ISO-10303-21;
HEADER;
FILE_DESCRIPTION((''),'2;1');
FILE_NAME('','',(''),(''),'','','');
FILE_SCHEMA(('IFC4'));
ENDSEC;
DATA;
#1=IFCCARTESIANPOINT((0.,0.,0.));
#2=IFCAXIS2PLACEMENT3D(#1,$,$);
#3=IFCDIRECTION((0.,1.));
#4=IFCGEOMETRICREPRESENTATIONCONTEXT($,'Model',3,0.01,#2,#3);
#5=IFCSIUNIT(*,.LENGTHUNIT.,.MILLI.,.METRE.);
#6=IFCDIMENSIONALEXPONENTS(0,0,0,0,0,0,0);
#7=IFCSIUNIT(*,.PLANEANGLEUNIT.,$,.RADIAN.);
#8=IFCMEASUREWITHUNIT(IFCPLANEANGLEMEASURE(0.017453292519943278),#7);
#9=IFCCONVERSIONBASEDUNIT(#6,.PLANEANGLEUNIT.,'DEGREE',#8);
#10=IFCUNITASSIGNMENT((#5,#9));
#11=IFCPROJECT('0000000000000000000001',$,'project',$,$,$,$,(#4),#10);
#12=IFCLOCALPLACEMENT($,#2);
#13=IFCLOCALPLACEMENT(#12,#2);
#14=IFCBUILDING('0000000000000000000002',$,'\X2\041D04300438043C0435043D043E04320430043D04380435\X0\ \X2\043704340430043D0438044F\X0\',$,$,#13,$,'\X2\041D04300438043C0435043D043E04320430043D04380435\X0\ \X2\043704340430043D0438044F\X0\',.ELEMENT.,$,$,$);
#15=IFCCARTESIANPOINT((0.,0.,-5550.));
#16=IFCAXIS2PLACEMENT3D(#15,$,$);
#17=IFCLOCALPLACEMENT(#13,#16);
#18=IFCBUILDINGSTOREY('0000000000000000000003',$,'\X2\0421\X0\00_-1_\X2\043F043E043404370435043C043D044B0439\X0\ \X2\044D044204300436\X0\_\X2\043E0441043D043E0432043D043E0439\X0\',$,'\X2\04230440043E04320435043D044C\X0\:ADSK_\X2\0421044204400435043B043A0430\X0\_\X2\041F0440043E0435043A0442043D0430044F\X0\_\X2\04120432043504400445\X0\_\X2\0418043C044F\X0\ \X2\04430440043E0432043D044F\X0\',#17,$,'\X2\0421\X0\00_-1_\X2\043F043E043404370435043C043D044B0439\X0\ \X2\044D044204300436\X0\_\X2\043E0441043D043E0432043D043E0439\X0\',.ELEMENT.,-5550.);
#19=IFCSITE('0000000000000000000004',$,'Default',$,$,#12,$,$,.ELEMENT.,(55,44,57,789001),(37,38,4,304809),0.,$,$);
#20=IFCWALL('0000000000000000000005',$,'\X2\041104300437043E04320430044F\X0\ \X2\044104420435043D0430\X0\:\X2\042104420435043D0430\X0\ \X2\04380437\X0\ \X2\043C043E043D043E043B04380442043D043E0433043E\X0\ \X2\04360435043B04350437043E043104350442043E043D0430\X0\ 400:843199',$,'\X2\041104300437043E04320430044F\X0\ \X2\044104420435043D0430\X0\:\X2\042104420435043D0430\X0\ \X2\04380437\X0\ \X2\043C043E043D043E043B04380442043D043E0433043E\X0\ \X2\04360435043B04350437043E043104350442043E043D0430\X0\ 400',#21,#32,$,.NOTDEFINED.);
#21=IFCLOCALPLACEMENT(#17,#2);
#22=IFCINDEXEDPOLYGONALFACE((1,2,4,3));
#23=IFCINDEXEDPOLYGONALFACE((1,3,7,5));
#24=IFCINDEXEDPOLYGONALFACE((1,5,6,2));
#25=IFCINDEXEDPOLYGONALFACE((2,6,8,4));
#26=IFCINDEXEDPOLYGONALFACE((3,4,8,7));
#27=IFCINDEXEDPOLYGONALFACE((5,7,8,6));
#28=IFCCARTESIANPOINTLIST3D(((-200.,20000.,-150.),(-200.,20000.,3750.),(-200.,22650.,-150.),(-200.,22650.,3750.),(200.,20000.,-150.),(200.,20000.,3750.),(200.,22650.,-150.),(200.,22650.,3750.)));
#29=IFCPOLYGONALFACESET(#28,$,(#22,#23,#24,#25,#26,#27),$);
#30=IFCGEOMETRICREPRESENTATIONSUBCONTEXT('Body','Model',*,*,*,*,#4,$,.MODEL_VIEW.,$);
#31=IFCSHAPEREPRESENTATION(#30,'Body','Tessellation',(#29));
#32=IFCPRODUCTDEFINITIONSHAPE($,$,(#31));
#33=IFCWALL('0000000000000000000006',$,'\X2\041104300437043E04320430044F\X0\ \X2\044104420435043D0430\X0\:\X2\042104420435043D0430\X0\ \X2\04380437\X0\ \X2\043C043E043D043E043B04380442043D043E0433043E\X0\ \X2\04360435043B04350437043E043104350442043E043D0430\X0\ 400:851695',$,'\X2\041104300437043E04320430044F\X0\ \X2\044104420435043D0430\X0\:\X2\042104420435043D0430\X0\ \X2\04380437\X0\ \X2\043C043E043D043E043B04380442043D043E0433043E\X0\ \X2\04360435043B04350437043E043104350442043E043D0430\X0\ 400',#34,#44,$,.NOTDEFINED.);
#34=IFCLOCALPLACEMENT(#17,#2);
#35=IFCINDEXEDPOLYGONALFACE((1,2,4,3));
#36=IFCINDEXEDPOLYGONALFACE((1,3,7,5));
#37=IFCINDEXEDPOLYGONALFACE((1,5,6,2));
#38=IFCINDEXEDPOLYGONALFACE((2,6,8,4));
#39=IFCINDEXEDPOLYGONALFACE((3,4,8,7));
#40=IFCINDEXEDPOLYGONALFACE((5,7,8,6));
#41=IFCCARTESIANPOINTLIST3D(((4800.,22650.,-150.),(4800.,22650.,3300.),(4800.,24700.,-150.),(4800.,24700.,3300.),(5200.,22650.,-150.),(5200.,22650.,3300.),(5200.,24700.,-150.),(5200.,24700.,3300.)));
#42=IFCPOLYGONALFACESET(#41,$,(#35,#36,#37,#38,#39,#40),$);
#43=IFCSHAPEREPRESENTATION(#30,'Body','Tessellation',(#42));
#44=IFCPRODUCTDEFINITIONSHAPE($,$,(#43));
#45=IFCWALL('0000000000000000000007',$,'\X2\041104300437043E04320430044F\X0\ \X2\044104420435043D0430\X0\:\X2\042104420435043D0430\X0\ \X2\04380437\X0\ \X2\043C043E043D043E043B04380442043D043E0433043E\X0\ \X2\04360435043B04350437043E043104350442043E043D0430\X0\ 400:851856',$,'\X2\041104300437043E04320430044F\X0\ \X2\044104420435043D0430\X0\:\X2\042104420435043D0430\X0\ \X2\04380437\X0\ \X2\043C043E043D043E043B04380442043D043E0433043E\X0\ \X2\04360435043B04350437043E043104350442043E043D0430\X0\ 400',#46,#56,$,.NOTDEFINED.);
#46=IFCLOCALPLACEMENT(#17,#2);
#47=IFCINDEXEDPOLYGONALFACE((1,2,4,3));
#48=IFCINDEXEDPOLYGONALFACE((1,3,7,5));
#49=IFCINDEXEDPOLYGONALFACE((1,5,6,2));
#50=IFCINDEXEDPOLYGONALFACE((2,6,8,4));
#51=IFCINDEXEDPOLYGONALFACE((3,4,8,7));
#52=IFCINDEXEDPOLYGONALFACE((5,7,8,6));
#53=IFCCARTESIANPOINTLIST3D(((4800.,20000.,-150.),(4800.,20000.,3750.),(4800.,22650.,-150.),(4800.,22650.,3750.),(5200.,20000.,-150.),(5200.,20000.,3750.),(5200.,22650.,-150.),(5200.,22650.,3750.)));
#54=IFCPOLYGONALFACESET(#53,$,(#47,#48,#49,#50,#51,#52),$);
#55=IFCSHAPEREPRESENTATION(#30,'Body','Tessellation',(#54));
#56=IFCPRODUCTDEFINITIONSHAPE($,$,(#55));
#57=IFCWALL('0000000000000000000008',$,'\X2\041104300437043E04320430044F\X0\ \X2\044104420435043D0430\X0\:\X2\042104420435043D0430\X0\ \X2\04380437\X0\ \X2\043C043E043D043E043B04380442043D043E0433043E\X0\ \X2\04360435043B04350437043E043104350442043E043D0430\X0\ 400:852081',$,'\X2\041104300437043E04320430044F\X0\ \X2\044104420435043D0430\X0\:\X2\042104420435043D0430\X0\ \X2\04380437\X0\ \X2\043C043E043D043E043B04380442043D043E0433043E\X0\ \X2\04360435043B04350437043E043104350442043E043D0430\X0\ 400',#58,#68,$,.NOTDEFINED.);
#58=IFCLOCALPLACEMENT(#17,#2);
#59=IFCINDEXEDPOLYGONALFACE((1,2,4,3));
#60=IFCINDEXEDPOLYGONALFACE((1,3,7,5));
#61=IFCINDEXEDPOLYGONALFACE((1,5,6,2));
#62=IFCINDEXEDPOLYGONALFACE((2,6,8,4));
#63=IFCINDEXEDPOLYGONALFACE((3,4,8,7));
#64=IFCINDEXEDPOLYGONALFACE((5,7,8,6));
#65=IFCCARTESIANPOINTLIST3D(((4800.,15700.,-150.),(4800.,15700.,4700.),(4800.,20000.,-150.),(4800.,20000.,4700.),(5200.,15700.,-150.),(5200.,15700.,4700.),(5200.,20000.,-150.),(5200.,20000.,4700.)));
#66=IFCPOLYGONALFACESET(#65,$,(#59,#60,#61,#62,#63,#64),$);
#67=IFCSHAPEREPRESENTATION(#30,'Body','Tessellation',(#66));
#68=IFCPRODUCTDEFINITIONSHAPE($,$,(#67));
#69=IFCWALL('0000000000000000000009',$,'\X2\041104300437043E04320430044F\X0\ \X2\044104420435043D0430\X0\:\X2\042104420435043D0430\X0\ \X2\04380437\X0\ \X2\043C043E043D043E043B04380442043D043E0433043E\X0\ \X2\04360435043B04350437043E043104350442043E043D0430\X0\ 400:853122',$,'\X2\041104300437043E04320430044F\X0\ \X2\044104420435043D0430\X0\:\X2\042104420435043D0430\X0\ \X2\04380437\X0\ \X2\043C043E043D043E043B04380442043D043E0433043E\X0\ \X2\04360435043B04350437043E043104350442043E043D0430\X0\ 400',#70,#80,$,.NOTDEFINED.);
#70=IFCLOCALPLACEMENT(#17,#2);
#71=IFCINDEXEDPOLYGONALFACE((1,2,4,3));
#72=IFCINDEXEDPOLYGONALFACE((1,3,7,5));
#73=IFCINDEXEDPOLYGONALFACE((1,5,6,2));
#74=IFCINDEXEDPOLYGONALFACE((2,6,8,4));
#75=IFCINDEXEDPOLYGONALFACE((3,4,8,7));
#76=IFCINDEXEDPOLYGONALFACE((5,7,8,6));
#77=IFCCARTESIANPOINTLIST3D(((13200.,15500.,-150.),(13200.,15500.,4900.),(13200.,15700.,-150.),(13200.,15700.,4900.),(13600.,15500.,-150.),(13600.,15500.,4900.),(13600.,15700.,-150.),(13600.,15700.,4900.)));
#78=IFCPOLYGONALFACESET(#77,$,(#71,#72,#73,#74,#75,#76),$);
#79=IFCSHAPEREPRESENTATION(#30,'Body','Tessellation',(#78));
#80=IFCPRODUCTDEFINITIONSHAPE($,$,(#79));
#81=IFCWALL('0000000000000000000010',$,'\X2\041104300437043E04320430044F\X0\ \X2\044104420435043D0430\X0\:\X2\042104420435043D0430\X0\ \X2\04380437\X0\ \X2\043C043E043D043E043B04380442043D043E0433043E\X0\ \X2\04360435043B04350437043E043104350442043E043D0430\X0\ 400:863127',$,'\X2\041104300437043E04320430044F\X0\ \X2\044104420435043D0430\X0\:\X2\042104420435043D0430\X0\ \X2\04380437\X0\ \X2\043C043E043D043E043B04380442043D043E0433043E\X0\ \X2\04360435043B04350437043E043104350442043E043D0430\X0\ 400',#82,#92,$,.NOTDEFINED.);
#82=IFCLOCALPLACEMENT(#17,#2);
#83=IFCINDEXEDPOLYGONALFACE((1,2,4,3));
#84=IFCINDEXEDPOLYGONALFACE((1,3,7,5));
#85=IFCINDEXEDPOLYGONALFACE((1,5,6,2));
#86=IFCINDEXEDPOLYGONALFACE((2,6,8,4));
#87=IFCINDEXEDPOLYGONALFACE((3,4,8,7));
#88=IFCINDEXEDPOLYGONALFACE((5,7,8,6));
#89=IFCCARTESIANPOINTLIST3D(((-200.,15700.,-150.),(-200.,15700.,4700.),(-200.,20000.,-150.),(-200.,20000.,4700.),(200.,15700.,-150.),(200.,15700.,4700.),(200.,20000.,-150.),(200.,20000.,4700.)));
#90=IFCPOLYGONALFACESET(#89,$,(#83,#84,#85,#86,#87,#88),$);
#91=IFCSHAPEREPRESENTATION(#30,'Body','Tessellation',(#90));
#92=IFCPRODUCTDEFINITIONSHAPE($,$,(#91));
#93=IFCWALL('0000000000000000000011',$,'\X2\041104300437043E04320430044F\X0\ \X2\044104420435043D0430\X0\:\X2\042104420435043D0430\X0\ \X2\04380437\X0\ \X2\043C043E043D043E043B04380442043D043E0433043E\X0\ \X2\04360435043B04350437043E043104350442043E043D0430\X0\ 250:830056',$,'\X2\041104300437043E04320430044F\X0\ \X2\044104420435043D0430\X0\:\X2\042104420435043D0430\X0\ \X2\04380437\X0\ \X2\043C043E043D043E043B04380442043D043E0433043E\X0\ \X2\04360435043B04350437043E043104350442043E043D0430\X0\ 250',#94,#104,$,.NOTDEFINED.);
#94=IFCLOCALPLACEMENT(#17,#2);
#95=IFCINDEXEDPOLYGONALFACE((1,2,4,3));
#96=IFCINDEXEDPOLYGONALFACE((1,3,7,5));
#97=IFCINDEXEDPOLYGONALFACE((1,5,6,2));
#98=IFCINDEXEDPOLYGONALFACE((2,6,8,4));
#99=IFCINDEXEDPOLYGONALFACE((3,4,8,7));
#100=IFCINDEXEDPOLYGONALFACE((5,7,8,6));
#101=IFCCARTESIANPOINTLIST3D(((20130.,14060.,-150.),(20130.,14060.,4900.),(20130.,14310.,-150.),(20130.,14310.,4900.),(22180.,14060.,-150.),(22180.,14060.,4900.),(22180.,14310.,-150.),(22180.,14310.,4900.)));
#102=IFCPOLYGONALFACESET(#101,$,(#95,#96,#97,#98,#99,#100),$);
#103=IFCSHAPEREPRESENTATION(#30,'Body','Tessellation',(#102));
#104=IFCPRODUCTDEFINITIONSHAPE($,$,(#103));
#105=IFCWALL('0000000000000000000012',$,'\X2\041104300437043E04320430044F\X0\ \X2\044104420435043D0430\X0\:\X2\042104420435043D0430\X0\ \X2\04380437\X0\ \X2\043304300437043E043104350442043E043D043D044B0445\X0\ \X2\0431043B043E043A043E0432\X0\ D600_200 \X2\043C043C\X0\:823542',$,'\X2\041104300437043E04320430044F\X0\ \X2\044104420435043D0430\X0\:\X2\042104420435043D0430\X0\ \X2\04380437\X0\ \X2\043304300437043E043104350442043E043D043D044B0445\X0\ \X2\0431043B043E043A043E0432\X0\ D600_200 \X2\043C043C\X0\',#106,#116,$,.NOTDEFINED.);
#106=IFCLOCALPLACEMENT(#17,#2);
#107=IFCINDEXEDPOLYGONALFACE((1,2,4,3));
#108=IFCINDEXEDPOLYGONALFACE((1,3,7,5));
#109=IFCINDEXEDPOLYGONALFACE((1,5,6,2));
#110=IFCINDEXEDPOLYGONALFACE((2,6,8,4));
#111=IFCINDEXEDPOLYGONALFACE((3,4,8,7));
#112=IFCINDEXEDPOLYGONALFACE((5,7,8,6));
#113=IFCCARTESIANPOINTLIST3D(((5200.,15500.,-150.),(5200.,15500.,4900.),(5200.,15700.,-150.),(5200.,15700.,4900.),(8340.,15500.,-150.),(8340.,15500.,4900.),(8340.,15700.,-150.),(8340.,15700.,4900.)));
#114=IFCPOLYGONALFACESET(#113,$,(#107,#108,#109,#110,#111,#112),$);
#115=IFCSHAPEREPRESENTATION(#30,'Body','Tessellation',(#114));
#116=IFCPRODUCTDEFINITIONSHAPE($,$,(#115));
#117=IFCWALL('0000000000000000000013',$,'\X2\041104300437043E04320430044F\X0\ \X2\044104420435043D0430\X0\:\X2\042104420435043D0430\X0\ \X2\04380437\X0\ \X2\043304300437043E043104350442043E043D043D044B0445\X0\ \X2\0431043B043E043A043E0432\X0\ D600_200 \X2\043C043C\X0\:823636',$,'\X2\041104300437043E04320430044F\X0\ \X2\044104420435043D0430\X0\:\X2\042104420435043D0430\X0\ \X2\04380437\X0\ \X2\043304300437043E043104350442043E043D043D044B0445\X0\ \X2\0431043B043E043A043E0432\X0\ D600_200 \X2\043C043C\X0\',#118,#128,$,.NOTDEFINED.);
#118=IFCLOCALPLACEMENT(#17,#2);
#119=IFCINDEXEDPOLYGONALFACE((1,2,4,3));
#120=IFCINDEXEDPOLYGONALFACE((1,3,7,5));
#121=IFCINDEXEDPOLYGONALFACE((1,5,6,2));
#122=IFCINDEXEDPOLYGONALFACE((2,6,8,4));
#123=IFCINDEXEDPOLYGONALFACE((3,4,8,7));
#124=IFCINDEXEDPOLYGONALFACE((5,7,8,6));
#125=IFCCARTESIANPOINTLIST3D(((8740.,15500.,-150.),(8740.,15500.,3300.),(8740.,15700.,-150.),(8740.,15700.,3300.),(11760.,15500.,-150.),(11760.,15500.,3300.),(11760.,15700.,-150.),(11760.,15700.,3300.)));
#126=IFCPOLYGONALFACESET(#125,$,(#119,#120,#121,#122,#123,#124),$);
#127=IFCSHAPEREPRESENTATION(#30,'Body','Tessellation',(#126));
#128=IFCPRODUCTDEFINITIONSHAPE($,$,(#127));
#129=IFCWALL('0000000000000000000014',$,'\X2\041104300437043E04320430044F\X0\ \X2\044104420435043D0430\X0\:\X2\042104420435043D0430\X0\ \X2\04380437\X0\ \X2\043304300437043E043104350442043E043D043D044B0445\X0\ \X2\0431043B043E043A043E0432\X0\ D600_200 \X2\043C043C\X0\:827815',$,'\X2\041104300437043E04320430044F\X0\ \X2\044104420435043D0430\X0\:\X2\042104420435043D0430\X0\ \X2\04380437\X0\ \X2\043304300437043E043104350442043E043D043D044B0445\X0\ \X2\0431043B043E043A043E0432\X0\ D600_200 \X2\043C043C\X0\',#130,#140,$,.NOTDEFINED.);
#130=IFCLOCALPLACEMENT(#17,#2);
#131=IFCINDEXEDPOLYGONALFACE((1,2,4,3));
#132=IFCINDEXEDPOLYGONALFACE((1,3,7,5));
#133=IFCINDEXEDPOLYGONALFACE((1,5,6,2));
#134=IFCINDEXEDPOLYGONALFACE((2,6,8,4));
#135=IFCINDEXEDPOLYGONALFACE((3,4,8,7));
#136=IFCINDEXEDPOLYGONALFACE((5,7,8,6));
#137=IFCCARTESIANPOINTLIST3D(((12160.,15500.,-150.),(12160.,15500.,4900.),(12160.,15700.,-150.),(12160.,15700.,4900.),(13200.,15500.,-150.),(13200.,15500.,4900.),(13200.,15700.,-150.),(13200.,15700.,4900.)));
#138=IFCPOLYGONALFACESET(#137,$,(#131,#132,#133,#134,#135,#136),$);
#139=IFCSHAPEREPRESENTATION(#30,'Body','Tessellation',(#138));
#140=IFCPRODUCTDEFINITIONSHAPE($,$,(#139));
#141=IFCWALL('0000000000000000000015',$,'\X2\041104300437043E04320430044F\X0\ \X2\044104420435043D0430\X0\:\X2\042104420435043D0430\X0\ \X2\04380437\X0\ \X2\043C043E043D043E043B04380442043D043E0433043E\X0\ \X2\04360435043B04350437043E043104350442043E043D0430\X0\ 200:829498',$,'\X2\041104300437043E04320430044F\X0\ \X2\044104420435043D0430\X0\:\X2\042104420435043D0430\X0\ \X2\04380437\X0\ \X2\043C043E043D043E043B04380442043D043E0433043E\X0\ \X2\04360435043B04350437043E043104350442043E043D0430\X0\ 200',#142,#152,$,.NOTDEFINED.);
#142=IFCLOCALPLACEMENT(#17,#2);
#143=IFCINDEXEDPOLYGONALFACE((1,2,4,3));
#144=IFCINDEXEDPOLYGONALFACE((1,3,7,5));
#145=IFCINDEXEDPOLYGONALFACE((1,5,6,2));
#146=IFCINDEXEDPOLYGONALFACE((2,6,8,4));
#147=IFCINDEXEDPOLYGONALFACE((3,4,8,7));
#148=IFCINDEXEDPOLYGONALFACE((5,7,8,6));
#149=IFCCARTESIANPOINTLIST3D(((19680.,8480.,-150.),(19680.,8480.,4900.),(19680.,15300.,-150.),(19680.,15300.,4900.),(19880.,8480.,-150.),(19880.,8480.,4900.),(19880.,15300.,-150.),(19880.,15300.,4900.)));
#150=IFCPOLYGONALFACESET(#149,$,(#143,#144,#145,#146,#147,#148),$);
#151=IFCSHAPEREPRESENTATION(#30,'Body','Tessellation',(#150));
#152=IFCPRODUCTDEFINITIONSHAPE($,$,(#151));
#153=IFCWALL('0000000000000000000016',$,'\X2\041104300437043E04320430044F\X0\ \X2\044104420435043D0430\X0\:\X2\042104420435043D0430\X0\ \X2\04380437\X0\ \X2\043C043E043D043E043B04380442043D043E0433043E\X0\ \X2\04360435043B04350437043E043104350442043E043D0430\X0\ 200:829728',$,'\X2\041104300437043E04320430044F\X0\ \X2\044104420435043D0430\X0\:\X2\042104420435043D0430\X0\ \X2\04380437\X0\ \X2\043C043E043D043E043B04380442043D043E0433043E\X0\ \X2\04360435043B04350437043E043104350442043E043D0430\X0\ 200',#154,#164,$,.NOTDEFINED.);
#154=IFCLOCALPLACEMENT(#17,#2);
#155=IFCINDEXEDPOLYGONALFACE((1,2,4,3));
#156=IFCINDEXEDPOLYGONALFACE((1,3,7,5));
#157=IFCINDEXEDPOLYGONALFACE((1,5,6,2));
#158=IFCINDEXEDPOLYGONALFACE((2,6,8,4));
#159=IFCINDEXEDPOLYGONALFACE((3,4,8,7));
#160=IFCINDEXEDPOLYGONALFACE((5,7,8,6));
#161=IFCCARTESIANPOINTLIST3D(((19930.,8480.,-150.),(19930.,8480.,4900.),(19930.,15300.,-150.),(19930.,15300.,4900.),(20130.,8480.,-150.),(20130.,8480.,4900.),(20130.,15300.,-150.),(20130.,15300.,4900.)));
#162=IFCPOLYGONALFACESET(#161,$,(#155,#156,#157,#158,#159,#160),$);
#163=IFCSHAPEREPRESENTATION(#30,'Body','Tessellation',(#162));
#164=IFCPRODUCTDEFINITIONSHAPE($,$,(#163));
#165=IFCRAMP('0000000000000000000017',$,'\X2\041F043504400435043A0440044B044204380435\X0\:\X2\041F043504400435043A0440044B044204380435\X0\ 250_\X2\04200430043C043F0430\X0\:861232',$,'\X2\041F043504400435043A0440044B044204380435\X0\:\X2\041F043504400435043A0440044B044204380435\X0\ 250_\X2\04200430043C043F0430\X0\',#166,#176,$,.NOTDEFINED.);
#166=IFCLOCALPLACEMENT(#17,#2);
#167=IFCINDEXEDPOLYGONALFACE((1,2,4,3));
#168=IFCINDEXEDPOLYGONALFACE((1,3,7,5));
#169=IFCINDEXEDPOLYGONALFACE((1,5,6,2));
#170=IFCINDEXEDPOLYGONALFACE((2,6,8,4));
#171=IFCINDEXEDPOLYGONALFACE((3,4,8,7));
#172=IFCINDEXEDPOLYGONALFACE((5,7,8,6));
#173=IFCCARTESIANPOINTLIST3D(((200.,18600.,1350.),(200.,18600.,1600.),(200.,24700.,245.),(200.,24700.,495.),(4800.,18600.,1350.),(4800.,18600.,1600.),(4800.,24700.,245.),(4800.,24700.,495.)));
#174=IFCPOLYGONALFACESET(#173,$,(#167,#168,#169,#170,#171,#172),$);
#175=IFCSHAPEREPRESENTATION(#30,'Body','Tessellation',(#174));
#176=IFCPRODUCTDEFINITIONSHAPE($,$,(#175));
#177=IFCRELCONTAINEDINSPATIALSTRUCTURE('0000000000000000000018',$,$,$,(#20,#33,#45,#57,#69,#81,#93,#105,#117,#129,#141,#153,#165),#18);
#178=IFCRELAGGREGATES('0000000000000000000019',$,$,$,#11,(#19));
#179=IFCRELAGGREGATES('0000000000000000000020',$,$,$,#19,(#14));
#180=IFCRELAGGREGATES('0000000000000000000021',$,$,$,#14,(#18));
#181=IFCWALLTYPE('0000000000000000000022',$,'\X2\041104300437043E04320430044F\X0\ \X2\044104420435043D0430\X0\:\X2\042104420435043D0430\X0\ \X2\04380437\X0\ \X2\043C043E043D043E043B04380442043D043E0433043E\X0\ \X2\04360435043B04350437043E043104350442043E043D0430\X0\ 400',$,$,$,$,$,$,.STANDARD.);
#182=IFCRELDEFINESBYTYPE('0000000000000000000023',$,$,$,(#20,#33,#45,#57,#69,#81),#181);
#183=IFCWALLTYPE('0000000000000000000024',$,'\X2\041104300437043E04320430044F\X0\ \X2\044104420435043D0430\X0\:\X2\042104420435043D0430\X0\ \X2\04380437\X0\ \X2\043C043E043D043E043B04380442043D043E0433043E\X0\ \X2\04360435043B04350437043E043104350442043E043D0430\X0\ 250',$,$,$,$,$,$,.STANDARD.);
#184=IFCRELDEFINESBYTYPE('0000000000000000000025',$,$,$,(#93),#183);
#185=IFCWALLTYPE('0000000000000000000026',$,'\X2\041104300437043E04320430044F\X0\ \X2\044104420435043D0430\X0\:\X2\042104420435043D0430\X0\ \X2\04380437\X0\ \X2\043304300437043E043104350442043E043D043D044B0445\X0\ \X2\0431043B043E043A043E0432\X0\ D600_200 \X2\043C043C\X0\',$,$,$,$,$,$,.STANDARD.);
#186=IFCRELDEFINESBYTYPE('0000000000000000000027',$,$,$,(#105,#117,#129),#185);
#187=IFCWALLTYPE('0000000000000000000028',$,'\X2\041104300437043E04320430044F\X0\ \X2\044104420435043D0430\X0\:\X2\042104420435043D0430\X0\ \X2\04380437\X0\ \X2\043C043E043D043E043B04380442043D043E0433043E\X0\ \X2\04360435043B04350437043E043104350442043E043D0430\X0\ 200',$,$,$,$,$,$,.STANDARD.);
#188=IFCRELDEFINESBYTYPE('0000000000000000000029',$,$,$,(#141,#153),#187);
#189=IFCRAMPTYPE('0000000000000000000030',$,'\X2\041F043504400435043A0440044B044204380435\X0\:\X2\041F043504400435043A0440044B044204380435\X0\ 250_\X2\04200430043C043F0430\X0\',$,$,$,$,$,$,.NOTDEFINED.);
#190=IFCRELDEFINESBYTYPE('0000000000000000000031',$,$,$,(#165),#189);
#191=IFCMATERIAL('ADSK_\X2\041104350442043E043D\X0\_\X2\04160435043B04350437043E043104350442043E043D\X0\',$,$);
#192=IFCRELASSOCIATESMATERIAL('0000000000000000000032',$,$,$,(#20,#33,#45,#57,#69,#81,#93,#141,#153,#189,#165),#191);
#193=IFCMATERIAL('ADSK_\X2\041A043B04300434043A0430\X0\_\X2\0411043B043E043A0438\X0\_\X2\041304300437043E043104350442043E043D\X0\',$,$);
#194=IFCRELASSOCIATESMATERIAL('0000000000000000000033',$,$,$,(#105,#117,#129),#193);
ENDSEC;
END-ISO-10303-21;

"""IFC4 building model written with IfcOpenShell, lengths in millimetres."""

from ifc_helpers import new_model, entity, si_unit, converted_unit, direction, frame, frame_2d, origin, place, context, subcontext, project, spatial, indexed_curve, rectangle, outline, extrude, material, type_object, element, save


model = new_model("IFC4")

# Units and contexts
model_context = context("Model", 3, precision=0.01, world=origin(), true_north=direction((0.0, 1.0)))
body_context = subcontext(model_context, "Body", "Model", "MODEL_VIEW")
ifc_project = project(units=[si_unit("LENGTHUNIT", "METRE", prefix="MILLI"), converted_unit("PLANEANGLEUNIT", "DEGREE", entity("IfcPlaneAngleMeasure", 0.017453292519943278), si_unit("PLANEANGLEUNIT", "RADIAN"), dimensions=[0, 0, 0, 0, 0, 0, 0])], contexts=[model_context])

# Site, building, storey
site_placement = place(None, origin())
site = spatial("IfcSite", under=ifc_project, at=site_placement, Name="Default", CompositionType="ELEMENT", RefLatitude=(55, 44, 57, 789001), RefLongitude=(37, 38, 4, 304809), RefElevation=0.0)
building_placement = place(site_placement, origin())
building = spatial("IfcBuilding", under=site, at=building_placement, Name="Наименование здания", LongName="Наименование здания", CompositionType="ELEMENT")
storey_placement = place(building_placement, frame((0.0, 0.0, -5550.0)))
storey = spatial("IfcBuildingStorey", under=building, at=storey_placement, Name="С00_-1_подземный этаж_основной", ObjectType="Уровень:ADSK_Стрелка_Проектная_Вверх_Имя уровня", LongName="С00_-1_подземный этаж_основной", CompositionType="ELEMENT", Elevation=-5550.0)

# Shared definitions
ifc_material_1 = material(Name="ADSK_Бетон_Железобетон")

# Walls
wall_type_1 = type_object("IfcWallType", Name="Базовая стена:Стена из монолитного железобетона 400", PredefinedType="STANDARD")
wall_1_placement = place(storey_placement, frame((0.0, 20000.0, -150.0), z_axis=(0.0, 0.0, 1.0), x_axis=(0.0, 1.0, 0.0)))
element("IfcWall", 1, at=wall_1_placement, inside=storey, type_object=wall_type_1, material=ifc_material_1, Name="Базовая стена:Стена из монолитного железобетона 400:843199", ObjectType="Базовая стена:Стена из монолитного железобетона 400", PredefinedType="NOTDEFINED", context=body_context, shape_type="SweptSolid", body=[
    extrude(outline(indexed_curve([(2650.0, 200.0), (0.0, 200.0), (0.0, -200.0), (2650.0, -200.0), (2650.0, 200.0)], self_intersect=False)), origin(), (0.0, 0.0, 1.0), 3900.0),
])
wall_2_placement = place(storey_placement, frame((5000.0, 22650.0, -150.0), z_axis=(0.0, 0.0, 1.0), x_axis=(0.0, 1.0, 0.0)))
element("IfcWall", 2, at=wall_2_placement, inside=storey, type_object=wall_type_1, material=ifc_material_1, Name="Базовая стена:Стена из монолитного железобетона 400:851695", ObjectType="Базовая стена:Стена из монолитного железобетона 400", PredefinedType="NOTDEFINED", context=body_context, shape_type="SweptSolid", body=[
    extrude(outline(indexed_curve([(2050.0, 200.0), (0.0, 200.0), (0.0, -200.0), (2050.0, -200.0), (2050.0, 200.0)], self_intersect=False)), origin(), (0.0, 0.0, 1.0), 3450.0),
])
wall_3_placement = place(storey_placement, frame((5000.0, 20000.0, -150.0), z_axis=(0.0, 0.0, 1.0), x_axis=(0.0, 1.0, 0.0)))
element("IfcWall", 3, at=wall_3_placement, inside=storey, type_object=wall_type_1, material=ifc_material_1, Name="Базовая стена:Стена из монолитного железобетона 400:851856", ObjectType="Базовая стена:Стена из монолитного железобетона 400", PredefinedType="NOTDEFINED", context=body_context, shape_type="SweptSolid", body=[
    extrude(outline(indexed_curve([(2650.0, 200.0), (0.0, 200.0), (0.0, -200.0), (2650.0, -200.0), (2650.0, 200.0)], self_intersect=False)), origin(), (0.0, 0.0, 1.0), 3900.0),
])
wall_4_placement = place(storey_placement, frame((5000.0, 15700.0, -150.0), z_axis=(0.0, 0.0, 1.0), x_axis=(0.0, 1.0, 0.0)))
element("IfcWall", 4, at=wall_4_placement, inside=storey, type_object=wall_type_1, material=ifc_material_1, Name="Базовая стена:Стена из монолитного железобетона 400:852081", ObjectType="Базовая стена:Стена из монолитного железобетона 400", PredefinedType="NOTDEFINED", context=body_context, shape_type="SweptSolid", body=[
    extrude(outline(indexed_curve([(4300.0, 200.0), (0.0, 200.0), (0.0, -200.0), (4300.0, -200.0), (4300.0, 200.0)], self_intersect=False)), origin(), (0.0, 0.0, 1.0), 4850.0),
])
wall_5_placement = place(storey_placement, frame((13400.0, 15700.0, -150.0), z_axis=(0.0, 0.0, 1.0), x_axis=(0.0, -1.0, 0.0)))
element("IfcWall", 5, at=wall_5_placement, inside=storey, type_object=wall_type_1, material=ifc_material_1, Name="Базовая стена:Стена из монолитного железобетона 400:853122", ObjectType="Базовая стена:Стена из монолитного железобетона 400", PredefinedType="NOTDEFINED", context=body_context, shape_type="SweptSolid", body=[
    extrude(outline(indexed_curve([(200.0, 200.0), (0.0, 200.0), (0.0, -200.0), (200.0, -200.0), (200.0, 200.0)], self_intersect=False)), origin(), (0.0, 0.0, 1.0), 5050.0),
])
wall_6_placement = place(storey_placement, frame((0.0, 15700.0, -150.0), z_axis=(0.0, 0.0, 1.0), x_axis=(0.0, 1.0, 0.0)))
element("IfcWall", 6, at=wall_6_placement, inside=storey, type_object=wall_type_1, material=ifc_material_1, Name="Базовая стена:Стена из монолитного железобетона 400:863127", ObjectType="Базовая стена:Стена из монолитного железобетона 400", PredefinedType="NOTDEFINED", context=body_context, shape_type="SweptSolid", body=[
    extrude(outline(indexed_curve([(4300.0, 200.0), (0.0, 200.0), (0.0, -200.0), (4300.0, -200.0), (4300.0, 200.0)], self_intersect=False)), origin(), (0.0, 0.0, 1.0), 4850.0),
])
wall_type_2 = type_object("IfcWallType", Name="Базовая стена:Стена из монолитного железобетона 250", PredefinedType="STANDARD")
wall_7_placement = place(storey_placement, frame((20130.0, 14185.0, -150.0)))
element("IfcWall", 7, at=wall_7_placement, inside=storey, type_object=wall_type_2, material=ifc_material_1, Name="Базовая стена:Стена из монолитного железобетона 250:830056", ObjectType="Базовая стена:Стена из монолитного железобетона 250", PredefinedType="NOTDEFINED", context=body_context, shape_type="SweptSolid", body=[
    extrude(outline(indexed_curve([(2050.0, 125.0), (0.0, 125.0), (0.0, -125.0), (2050.0, -125.0), (2050.0, 125.0)], self_intersect=False)), origin(), (0.0, 0.0, 1.0), 5050.0),
])
ifc_material_2 = material(Name="ADSK_Кладка_Блоки_Газобетон")
wall_type_3 = type_object("IfcWallType", Name="Базовая стена:Стена из газобетонных блоков D600_200 мм", PredefinedType="STANDARD")
wall_8_placement = place(storey_placement, frame((8340.0, 15600.0, -150.0), z_axis=(0.0, 0.0, 1.0), x_axis=(-1.0, 0.0, 0.0)))
element("IfcWall", 8, at=wall_8_placement, inside=storey, type_object=wall_type_3, material=ifc_material_2, Name="Базовая стена:Стена из газобетонных блоков D600_200 мм:823542", ObjectType="Базовая стена:Стена из газобетонных блоков D600_200 мм", PredefinedType="NOTDEFINED", context=body_context, shape_type="SweptSolid", body=[
    extrude(outline(indexed_curve([(3140.0, 100.0), (0.0, 100.0), (0.0, -100.0), (3140.0, -100.0), (3140.0, 100.0)], self_intersect=False)), origin(), (0.0, 0.0, 1.0), 5050.0),
])
wall_9_placement = place(storey_placement, frame((8740.0, 15600.0, -150.0)))
element("IfcWall", 9, at=wall_9_placement, inside=storey, type_object=wall_type_3, material=ifc_material_2, Name="Базовая стена:Стена из газобетонных блоков D600_200 мм:823636", ObjectType="Базовая стена:Стена из газобетонных блоков D600_200 мм", PredefinedType="NOTDEFINED", context=body_context, shape_type="SweptSolid", body=[
    extrude(outline(indexed_curve([(3020.0, 100.0), (0.0, 100.0), (0.0, -100.0), (3020.0, -100.0), (3020.0, 100.0)], self_intersect=False)), origin(), (0.0, 0.0, 1.0), 3450.0),
])
wall_10_placement = place(storey_placement, frame((12160.0, 15600.0, -150.0)))
element("IfcWall", 10, at=wall_10_placement, inside=storey, type_object=wall_type_3, material=ifc_material_2, Name="Базовая стена:Стена из газобетонных блоков D600_200 мм:827815", ObjectType="Базовая стена:Стена из газобетонных блоков D600_200 мм", PredefinedType="NOTDEFINED", context=body_context, shape_type="SweptSolid", body=[
    extrude(outline(indexed_curve([(1040.0, 100.0), (0.0, 100.0), (0.0, -100.0), (1040.0, -100.0), (1040.0, 100.0)], self_intersect=False)), origin(), (0.0, 0.0, 1.0), 5050.0),
])
wall_type_4 = type_object("IfcWallType", Name="Базовая стена:Стена из монолитного железобетона 200", PredefinedType="STANDARD")
for number, where, z_axis, x_axis, name in (
    (11, (19780.0, 15300.0, -150.0), (0.0, 0.0, 1.0), (0.0, -1.0, 0.0), "Базовая стена:Стена из монолитного железобетона 200:829498"),
    (12, (20030.0, 15300.0, -150.0), (0.0, 0.0, 1.0), (0.0, -1.0, 0.0), "Базовая стена:Стена из монолитного железобетона 200:829728"),
):
    element("IfcWall", number, at=place(storey_placement, frame(where, z_axis=z_axis, x_axis=x_axis)), inside=storey, type_object=wall_type_4, material=ifc_material_1, Name=name, ObjectType="Базовая стена:Стена из монолитного железобетона 200", PredefinedType="NOTDEFINED", context=body_context, shape_type="SweptSolid", body=[
        extrude(outline(indexed_curve([(6820.0, 100.0), (0.0, 100.0), (0.0, -100.0), (6820.0, -100.0), (6820.0, 100.0)], self_intersect=False)), origin(), (0.0, 0.0, 1.0), 5050.0),
    ])

# Ramp
ramp_type = type_object("IfcRampType", Name="Перекрытие:Перекрытие 250_Рампа", PredefinedType="NOTDEFINED", material=ifc_material_1)
ramp_placement = place(storey_placement, frame((200.0, 18600.0, 245.0)))
element("IfcRamp", 13, at=ramp_placement, inside=storey, type_object=ramp_type, material=ifc_material_1, Name="Перекрытие:Перекрытие 250_Рампа:861232", ObjectType="Перекрытие:Перекрытие 250_Рампа", PredefinedType="NOTDEFINED", context=body_context, shape_type="SweptSolid", body=[
    extrude(rectangle(XDim=6199.3, YDim=4600.0, at=frame_2d((0.0, 0.0), x_axis=(0.0, 1.0))), frame((2300.0, 3050.0, 802.5), z_axis=(0.0, 0.178247, 0.983986), x_axis=(1.0, 0.0, 0.0)), (0.0, 0.178247, -0.983986), 250.0),
])

save(model, "model.ifc")
